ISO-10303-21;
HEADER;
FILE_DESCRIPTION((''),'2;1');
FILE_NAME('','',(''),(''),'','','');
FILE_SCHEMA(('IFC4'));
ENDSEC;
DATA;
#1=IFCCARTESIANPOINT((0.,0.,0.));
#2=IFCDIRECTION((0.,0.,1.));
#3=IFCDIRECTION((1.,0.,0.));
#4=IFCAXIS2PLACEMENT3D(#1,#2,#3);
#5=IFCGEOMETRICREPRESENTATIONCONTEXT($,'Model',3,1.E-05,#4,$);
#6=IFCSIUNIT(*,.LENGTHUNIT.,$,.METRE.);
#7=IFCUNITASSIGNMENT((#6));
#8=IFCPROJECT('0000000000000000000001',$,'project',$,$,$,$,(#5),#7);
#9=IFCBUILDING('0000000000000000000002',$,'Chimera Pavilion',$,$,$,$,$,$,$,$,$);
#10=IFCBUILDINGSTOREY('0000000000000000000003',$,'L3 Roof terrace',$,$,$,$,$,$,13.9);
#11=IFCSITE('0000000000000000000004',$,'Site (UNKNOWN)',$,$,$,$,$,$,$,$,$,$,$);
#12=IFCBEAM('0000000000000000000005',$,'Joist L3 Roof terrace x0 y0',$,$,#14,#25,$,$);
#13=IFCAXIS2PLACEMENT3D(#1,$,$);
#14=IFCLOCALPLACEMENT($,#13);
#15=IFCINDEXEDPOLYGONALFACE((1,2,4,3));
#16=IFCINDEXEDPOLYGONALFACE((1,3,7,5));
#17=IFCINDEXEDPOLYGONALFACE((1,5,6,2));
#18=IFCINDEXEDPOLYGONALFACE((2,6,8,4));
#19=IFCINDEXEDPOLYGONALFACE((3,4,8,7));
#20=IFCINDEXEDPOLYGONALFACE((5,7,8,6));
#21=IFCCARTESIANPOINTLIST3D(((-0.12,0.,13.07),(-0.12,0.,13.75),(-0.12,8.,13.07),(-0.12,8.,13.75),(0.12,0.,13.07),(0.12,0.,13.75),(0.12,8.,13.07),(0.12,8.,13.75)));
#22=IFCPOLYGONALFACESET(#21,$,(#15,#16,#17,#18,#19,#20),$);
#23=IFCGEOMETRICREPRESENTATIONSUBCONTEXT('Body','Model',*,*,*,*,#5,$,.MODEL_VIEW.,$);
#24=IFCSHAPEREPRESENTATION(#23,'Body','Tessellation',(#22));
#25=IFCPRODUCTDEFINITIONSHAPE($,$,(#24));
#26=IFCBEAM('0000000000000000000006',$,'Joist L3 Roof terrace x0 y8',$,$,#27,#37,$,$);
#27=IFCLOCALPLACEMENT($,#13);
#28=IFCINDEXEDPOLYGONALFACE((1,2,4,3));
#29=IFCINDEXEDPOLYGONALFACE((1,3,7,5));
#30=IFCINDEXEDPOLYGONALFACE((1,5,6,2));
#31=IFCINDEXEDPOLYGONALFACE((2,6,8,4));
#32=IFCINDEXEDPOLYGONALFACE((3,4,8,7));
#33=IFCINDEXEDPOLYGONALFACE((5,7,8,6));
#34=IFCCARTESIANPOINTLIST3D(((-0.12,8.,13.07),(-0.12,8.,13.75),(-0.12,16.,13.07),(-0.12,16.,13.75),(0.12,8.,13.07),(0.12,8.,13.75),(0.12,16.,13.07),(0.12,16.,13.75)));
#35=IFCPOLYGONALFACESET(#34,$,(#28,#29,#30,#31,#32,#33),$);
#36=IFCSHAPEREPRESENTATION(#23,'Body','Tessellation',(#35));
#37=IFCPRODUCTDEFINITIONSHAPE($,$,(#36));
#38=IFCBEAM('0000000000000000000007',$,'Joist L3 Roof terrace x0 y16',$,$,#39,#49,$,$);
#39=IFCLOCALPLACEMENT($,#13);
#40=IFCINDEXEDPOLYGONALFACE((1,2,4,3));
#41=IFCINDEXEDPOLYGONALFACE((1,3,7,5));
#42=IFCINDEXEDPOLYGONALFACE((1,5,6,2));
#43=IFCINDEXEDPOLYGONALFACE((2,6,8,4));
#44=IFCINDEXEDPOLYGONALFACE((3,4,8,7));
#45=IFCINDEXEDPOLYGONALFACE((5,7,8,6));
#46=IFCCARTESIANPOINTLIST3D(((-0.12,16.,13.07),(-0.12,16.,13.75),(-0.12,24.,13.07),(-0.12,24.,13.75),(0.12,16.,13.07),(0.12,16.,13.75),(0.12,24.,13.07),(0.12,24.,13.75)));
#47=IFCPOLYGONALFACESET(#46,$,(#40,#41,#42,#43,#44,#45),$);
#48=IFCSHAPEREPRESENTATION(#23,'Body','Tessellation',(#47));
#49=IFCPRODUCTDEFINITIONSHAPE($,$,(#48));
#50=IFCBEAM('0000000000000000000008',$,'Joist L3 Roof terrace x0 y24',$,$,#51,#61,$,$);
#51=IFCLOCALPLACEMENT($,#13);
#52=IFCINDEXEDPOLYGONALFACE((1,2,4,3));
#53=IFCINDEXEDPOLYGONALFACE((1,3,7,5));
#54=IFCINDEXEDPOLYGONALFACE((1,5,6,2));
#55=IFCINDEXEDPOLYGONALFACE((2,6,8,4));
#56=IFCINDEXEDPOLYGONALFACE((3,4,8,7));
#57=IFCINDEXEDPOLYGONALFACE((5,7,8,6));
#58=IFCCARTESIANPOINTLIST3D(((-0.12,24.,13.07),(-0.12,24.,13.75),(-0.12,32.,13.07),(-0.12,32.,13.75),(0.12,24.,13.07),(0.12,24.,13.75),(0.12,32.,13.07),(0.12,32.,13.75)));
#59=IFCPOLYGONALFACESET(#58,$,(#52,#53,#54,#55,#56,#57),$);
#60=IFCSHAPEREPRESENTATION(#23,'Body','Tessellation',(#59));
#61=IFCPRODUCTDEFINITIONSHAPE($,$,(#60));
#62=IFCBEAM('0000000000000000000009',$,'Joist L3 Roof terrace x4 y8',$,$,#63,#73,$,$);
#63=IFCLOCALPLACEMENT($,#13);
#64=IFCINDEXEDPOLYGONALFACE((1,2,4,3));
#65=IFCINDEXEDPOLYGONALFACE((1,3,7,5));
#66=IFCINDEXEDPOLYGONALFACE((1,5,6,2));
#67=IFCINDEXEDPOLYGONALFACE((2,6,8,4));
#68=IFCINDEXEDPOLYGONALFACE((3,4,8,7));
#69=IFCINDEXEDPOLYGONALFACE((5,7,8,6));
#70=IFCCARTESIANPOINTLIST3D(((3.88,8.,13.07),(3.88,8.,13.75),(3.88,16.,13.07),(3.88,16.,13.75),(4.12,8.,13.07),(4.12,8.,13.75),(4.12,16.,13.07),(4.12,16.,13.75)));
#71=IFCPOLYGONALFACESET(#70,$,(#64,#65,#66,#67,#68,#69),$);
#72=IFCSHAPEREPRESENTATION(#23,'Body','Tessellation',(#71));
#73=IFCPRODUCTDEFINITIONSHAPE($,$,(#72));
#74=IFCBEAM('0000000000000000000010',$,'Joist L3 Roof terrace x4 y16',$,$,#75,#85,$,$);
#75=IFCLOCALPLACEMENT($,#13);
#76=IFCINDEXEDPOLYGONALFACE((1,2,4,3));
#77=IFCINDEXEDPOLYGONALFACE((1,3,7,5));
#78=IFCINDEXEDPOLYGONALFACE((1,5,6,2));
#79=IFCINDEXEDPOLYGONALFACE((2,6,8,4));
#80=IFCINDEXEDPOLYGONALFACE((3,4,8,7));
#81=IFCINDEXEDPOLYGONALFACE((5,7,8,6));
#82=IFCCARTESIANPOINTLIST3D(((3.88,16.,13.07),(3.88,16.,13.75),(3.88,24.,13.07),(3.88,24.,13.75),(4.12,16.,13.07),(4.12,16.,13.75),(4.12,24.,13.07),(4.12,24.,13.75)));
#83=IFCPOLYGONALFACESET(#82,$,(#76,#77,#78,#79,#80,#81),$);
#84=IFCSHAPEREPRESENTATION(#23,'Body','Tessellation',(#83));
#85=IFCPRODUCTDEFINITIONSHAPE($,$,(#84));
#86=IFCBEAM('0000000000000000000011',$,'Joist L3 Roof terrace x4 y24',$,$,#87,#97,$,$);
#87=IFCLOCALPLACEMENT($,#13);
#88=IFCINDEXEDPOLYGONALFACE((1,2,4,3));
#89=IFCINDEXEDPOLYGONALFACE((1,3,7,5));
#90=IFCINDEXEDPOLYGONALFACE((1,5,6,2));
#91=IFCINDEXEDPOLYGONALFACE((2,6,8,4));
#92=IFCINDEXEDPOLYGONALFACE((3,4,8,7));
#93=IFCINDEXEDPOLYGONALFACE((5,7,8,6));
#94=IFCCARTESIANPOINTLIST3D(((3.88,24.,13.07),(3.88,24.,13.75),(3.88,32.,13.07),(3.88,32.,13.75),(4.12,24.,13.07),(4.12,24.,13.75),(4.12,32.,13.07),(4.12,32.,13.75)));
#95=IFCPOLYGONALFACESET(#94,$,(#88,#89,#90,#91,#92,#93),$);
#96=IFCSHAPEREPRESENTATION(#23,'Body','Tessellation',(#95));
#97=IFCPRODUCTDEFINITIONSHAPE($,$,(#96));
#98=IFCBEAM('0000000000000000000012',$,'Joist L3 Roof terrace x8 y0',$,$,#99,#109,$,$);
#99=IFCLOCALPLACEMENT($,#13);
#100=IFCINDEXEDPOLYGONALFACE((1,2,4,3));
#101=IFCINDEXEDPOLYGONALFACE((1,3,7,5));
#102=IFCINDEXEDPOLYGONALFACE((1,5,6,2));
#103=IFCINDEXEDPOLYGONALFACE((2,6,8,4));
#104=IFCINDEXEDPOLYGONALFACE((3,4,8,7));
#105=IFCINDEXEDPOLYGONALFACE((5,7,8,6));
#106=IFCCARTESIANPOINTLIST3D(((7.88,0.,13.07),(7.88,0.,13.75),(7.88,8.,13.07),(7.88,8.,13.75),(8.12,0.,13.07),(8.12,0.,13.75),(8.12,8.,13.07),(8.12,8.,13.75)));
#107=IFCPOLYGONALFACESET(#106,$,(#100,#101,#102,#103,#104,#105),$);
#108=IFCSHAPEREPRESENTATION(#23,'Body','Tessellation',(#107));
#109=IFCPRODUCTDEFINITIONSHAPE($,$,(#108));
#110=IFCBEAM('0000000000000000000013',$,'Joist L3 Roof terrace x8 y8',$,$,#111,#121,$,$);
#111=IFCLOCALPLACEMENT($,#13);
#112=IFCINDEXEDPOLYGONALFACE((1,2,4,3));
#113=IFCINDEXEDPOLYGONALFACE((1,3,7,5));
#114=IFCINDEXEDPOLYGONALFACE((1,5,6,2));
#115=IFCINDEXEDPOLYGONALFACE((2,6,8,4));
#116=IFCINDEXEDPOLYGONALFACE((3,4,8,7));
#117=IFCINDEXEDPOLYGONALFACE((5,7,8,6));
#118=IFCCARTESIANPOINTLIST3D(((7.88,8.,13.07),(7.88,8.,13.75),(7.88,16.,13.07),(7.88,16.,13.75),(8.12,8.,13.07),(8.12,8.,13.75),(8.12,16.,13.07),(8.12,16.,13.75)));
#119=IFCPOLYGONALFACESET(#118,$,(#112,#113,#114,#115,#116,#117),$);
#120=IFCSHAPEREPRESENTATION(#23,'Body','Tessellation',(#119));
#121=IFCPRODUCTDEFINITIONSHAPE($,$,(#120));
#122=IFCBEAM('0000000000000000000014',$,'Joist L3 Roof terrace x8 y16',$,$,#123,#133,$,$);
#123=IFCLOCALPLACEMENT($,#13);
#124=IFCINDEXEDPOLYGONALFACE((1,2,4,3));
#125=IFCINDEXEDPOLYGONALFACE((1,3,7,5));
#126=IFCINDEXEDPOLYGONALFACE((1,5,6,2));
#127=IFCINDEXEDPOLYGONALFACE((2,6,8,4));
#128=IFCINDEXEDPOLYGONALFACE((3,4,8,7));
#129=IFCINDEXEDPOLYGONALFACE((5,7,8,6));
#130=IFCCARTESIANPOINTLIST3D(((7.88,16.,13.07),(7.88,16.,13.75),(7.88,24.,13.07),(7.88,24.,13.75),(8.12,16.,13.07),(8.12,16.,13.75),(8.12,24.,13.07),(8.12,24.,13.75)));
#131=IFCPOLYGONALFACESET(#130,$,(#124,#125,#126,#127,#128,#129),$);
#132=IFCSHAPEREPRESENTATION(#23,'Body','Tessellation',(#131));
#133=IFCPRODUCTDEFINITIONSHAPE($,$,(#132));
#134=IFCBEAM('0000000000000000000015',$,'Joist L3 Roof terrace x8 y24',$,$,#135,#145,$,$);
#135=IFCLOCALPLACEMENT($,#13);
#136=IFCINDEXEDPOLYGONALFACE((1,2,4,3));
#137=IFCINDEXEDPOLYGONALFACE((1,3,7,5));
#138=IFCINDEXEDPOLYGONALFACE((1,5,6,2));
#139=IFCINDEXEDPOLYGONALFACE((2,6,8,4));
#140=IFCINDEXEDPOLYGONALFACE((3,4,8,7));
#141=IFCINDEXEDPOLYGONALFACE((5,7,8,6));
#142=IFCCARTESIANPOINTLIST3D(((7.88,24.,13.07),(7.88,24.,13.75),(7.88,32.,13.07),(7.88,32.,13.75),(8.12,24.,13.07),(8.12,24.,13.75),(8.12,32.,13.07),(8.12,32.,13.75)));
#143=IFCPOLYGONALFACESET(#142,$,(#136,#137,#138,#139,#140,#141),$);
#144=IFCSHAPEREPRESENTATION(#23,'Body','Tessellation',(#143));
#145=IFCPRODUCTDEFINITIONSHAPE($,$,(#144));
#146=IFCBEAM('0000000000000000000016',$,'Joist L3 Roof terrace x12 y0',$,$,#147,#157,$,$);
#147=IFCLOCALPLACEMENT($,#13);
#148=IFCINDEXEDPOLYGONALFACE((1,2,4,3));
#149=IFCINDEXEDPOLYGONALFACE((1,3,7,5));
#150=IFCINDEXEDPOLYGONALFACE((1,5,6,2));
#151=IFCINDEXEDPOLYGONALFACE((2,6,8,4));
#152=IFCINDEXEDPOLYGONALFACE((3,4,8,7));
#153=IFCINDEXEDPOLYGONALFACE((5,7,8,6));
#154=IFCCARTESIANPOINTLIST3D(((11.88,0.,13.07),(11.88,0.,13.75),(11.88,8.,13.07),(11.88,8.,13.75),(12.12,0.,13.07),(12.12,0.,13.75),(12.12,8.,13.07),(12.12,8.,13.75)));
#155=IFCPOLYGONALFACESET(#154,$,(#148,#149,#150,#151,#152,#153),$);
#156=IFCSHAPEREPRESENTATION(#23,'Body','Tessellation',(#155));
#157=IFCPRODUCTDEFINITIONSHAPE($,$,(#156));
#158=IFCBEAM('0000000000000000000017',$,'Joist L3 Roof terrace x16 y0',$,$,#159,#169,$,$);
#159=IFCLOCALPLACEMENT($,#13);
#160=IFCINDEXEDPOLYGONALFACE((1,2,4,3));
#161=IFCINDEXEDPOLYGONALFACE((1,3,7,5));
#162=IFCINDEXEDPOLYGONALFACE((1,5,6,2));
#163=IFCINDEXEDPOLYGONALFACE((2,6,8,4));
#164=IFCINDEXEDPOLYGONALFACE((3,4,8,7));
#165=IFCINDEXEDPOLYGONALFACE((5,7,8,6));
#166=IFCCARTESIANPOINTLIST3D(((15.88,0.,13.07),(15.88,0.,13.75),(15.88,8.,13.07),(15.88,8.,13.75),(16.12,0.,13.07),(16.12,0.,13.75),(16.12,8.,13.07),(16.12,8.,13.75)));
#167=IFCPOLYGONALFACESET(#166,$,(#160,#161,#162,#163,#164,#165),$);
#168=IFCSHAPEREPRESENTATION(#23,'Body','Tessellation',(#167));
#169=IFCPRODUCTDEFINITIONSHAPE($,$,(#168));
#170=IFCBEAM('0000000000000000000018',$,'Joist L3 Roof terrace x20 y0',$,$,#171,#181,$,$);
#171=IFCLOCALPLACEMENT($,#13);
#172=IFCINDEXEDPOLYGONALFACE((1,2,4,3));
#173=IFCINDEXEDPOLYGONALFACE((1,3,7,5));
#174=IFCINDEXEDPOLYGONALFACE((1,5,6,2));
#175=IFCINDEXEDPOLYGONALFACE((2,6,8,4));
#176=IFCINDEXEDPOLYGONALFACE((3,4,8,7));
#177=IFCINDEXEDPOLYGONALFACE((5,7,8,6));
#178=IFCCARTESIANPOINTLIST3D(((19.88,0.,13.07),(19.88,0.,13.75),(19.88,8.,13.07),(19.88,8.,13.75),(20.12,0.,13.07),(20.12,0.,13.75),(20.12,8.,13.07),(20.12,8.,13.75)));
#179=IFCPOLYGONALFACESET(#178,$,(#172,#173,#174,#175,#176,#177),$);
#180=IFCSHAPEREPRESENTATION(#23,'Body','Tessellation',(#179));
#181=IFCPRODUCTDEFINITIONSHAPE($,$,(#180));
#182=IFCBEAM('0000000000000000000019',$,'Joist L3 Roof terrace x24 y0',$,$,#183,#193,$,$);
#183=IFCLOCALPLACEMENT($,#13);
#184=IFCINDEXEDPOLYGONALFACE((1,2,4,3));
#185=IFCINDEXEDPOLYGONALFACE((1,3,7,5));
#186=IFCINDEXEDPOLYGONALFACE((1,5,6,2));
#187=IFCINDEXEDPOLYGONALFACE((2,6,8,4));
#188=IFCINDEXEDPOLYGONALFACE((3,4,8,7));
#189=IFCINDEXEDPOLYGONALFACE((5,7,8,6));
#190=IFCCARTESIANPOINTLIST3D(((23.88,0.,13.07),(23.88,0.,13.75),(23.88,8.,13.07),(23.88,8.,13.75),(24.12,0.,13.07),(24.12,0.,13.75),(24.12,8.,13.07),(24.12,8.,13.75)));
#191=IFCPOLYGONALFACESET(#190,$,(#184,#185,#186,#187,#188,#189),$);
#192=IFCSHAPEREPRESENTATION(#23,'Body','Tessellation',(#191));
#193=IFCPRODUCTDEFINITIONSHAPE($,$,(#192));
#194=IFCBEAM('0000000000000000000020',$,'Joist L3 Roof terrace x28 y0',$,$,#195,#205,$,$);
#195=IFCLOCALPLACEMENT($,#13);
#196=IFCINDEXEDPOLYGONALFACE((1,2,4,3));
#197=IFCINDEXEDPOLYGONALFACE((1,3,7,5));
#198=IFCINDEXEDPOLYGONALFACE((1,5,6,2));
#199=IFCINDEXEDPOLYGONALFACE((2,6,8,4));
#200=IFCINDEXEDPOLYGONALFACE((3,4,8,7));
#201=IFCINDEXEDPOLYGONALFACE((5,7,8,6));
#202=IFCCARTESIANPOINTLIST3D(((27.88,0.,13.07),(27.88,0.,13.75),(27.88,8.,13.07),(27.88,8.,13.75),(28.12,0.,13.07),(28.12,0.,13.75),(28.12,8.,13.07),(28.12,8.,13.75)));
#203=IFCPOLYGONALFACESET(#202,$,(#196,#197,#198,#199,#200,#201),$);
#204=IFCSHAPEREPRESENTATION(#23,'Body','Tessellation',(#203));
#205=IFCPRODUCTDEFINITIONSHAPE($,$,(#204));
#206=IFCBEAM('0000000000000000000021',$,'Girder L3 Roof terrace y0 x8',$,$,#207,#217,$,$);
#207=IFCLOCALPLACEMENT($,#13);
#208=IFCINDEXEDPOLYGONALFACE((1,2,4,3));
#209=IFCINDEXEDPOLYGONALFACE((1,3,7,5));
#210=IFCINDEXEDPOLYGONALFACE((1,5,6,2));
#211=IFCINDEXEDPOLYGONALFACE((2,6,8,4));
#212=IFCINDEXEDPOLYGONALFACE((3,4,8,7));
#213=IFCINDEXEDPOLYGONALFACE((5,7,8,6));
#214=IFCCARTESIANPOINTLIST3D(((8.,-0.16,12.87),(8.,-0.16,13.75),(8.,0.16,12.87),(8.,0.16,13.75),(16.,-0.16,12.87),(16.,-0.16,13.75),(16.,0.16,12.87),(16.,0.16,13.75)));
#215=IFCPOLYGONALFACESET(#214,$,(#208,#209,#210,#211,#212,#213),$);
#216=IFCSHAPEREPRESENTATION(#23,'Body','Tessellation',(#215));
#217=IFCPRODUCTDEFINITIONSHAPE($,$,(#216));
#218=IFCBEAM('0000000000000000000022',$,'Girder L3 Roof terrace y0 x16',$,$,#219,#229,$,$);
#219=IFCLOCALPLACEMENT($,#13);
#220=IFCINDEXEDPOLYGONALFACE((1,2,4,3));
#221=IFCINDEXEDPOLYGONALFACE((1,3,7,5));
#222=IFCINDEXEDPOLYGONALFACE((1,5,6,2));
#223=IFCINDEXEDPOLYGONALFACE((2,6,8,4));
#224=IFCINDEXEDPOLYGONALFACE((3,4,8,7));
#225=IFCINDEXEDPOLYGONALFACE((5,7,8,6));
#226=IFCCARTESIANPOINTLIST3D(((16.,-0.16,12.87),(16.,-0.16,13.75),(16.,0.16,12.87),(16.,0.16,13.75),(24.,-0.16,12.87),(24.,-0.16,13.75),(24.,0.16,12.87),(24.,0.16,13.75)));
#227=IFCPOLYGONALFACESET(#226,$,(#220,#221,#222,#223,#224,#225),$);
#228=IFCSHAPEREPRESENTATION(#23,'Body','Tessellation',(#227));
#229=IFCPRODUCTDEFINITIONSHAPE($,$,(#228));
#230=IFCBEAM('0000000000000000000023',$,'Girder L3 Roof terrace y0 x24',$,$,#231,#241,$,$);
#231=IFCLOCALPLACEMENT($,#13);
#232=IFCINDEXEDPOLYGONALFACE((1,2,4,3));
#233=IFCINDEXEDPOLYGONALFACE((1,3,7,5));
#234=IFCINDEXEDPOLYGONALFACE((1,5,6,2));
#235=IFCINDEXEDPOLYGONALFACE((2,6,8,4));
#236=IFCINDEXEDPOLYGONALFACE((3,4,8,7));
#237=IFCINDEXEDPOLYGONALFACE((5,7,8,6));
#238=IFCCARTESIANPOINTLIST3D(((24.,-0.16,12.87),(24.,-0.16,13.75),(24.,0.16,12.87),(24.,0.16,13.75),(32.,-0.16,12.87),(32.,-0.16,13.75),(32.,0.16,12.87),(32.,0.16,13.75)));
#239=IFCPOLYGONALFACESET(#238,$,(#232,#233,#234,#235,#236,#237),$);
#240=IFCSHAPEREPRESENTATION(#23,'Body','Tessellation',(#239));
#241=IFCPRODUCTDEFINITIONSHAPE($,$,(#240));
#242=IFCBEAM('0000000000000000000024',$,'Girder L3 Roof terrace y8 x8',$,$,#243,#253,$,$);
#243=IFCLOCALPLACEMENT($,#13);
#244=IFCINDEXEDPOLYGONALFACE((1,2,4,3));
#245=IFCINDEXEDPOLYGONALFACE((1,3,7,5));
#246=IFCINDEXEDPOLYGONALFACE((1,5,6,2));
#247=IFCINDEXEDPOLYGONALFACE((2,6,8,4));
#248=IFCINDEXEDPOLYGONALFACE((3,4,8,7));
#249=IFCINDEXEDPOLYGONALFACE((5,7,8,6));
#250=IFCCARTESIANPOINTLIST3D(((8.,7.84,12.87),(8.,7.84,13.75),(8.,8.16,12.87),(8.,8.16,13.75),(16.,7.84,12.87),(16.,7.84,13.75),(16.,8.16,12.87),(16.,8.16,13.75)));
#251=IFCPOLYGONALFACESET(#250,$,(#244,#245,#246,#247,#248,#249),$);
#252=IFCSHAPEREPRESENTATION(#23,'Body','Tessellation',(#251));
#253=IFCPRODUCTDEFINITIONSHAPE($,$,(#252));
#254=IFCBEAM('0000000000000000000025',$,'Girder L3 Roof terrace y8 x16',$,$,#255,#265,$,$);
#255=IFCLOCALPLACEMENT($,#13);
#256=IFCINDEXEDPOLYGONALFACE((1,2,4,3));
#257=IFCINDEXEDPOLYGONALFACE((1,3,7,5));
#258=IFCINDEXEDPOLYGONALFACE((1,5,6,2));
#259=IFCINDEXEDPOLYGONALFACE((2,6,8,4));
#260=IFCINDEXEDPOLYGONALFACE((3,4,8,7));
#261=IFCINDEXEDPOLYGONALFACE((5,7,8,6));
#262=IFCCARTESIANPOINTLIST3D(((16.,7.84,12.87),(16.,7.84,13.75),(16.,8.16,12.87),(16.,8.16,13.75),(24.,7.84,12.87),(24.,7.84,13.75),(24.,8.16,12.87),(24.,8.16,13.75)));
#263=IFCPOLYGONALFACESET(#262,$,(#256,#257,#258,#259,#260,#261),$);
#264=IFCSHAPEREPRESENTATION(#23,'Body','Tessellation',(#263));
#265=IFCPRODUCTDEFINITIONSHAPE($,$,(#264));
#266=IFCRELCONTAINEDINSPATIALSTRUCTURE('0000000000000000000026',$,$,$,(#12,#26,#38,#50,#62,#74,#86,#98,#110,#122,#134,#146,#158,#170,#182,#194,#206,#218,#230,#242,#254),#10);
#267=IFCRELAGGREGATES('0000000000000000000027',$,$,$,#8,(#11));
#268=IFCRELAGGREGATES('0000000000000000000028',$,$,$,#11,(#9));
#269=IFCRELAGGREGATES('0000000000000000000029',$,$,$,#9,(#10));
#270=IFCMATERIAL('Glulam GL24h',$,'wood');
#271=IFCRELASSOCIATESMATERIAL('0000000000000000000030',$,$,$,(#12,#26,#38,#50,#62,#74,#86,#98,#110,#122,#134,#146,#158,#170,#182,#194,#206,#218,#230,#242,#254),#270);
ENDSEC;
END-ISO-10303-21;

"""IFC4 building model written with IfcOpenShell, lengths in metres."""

from ifc_helpers import new_model, si_unit, frame, origin_with_axes, place, context, subcontext, project, spatial, rectangle, extrude, material, element, save


model = new_model("IFC4")

# Units and contexts
model_context = context("Model", 3, precision=1e-05, world=origin_with_axes())
body_context = subcontext(model_context, "Body", "Model", "MODEL_VIEW")
ifc_project = project(units=[si_unit("LENGTHUNIT", "METRE")], contexts=[model_context])

# Site, building, storey
site = spatial("IfcSite", under=ifc_project, Name="Site (UNKNOWN)")
building = spatial("IfcBuilding", under=site, Name="Chimera Pavilion")
storey = spatial("IfcBuildingStorey", under=building, Name="L3 Roof terrace", Elevation=13.9)

# Beams
ifc_material_1 = material(Name="Glulam GL24h", Category="wood")
for number, where, z_axis, x_axis, name in (
    (1, (0.0, 0.0, 13.41), (0.0, 1.0, 0.0), (1.0, 0.0, 0.0), "Joist L3 Roof terrace x0 y0"),
    (2, (0.0, 8.0, 13.41), (0.0, 1.0, 0.0), (1.0, 0.0, 0.0), "Joist L3 Roof terrace x0 y8"),
    (3, (0.0, 16.0, 13.41), (0.0, 1.0, 0.0), (1.0, 0.0, 0.0), "Joist L3 Roof terrace x0 y16"),
    (4, (0.0, 24.0, 13.41), (0.0, 1.0, 0.0), (1.0, 0.0, 0.0), "Joist L3 Roof terrace x0 y24"),
    (5, (4.0, 8.0, 13.41), (0.0, 1.0, 0.0), (1.0, 0.0, 0.0), "Joist L3 Roof terrace x4 y8"),
    (6, (4.0, 16.0, 13.41), (0.0, 1.0, 0.0), (1.0, 0.0, 0.0), "Joist L3 Roof terrace x4 y16"),
    (7, (4.0, 24.0, 13.41), (0.0, 1.0, 0.0), (1.0, 0.0, 0.0), "Joist L3 Roof terrace x4 y24"),
    (8, (8.0, 0.0, 13.41), (0.0, 1.0, 0.0), (1.0, 0.0, 0.0), "Joist L3 Roof terrace x8 y0"),
    (9, (8.0, 8.0, 13.41), (0.0, 1.0, 0.0), (1.0, 0.0, 0.0), "Joist L3 Roof terrace x8 y8"),
    (10, (8.0, 16.0, 13.41), (0.0, 1.0, 0.0), (1.0, 0.0, 0.0), "Joist L3 Roof terrace x8 y16"),
    (11, (8.0, 24.0, 13.41), (0.0, 1.0, 0.0), (1.0, 0.0, 0.0), "Joist L3 Roof terrace x8 y24"),
    (12, (12.0, 0.0, 13.41), (0.0, 1.0, 0.0), (1.0, 0.0, 0.0), "Joist L3 Roof terrace x12 y0"),
    (13, (16.0, 0.0, 13.41), (0.0, 1.0, 0.0), (1.0, 0.0, 0.0), "Joist L3 Roof terrace x16 y0"),
    (14, (20.0, 0.0, 13.41), (0.0, 1.0, 0.0), (1.0, 0.0, 0.0), "Joist L3 Roof terrace x20 y0"),
    (15, (24.0, 0.0, 13.41), (0.0, 1.0, 0.0), (1.0, 0.0, 0.0), "Joist L3 Roof terrace x24 y0"),
    (16, (28.0, 0.0, 13.41), (0.0, 1.0, 0.0), (1.0, 0.0, 0.0), "Joist L3 Roof terrace x28 y0"),
):
    element("IfcBeam", number, at=place(None, frame(where, z_axis=z_axis, x_axis=x_axis)), inside=storey, material=ifc_material_1, Name=name, context=body_context, shape_type="SweptSolid", body=[
        extrude(rectangle(XDim=0.24, YDim=0.68), origin_with_axes(), (0.0, 0.0, 1.0), 8.0),
    ])
for number, where, z_axis, x_axis, name in (
    (17, (8.0, 0.0, 13.31), (1.0, 0.0, 0.0), (0.0, -1.0, 0.0), "Girder L3 Roof terrace y0 x8"),
    (18, (16.0, 0.0, 13.31), (1.0, 0.0, 0.0), (0.0, -1.0, 0.0), "Girder L3 Roof terrace y0 x16"),
    (19, (24.0, 0.0, 13.31), (1.0, 0.0, 0.0), (0.0, -1.0, 0.0), "Girder L3 Roof terrace y0 x24"),
    (20, (8.0, 8.0, 13.31), (1.0, 0.0, 0.0), (0.0, -1.0, 0.0), "Girder L3 Roof terrace y8 x8"),
    (21, (16.0, 8.0, 13.31), (1.0, 0.0, 0.0), (0.0, -1.0, 0.0), "Girder L3 Roof terrace y8 x16"),
):
    element("IfcBeam", number, at=place(None, frame(where, z_axis=z_axis, x_axis=x_axis)), inside=storey, material=ifc_material_1, Name=name, context=body_context, shape_type="SweptSolid", body=[
        extrude(rectangle(XDim=0.32, YDim=0.88), origin_with_axes(), (0.0, 0.0, 1.0), 8.0),
    ])

save(model, "model.ifc")
